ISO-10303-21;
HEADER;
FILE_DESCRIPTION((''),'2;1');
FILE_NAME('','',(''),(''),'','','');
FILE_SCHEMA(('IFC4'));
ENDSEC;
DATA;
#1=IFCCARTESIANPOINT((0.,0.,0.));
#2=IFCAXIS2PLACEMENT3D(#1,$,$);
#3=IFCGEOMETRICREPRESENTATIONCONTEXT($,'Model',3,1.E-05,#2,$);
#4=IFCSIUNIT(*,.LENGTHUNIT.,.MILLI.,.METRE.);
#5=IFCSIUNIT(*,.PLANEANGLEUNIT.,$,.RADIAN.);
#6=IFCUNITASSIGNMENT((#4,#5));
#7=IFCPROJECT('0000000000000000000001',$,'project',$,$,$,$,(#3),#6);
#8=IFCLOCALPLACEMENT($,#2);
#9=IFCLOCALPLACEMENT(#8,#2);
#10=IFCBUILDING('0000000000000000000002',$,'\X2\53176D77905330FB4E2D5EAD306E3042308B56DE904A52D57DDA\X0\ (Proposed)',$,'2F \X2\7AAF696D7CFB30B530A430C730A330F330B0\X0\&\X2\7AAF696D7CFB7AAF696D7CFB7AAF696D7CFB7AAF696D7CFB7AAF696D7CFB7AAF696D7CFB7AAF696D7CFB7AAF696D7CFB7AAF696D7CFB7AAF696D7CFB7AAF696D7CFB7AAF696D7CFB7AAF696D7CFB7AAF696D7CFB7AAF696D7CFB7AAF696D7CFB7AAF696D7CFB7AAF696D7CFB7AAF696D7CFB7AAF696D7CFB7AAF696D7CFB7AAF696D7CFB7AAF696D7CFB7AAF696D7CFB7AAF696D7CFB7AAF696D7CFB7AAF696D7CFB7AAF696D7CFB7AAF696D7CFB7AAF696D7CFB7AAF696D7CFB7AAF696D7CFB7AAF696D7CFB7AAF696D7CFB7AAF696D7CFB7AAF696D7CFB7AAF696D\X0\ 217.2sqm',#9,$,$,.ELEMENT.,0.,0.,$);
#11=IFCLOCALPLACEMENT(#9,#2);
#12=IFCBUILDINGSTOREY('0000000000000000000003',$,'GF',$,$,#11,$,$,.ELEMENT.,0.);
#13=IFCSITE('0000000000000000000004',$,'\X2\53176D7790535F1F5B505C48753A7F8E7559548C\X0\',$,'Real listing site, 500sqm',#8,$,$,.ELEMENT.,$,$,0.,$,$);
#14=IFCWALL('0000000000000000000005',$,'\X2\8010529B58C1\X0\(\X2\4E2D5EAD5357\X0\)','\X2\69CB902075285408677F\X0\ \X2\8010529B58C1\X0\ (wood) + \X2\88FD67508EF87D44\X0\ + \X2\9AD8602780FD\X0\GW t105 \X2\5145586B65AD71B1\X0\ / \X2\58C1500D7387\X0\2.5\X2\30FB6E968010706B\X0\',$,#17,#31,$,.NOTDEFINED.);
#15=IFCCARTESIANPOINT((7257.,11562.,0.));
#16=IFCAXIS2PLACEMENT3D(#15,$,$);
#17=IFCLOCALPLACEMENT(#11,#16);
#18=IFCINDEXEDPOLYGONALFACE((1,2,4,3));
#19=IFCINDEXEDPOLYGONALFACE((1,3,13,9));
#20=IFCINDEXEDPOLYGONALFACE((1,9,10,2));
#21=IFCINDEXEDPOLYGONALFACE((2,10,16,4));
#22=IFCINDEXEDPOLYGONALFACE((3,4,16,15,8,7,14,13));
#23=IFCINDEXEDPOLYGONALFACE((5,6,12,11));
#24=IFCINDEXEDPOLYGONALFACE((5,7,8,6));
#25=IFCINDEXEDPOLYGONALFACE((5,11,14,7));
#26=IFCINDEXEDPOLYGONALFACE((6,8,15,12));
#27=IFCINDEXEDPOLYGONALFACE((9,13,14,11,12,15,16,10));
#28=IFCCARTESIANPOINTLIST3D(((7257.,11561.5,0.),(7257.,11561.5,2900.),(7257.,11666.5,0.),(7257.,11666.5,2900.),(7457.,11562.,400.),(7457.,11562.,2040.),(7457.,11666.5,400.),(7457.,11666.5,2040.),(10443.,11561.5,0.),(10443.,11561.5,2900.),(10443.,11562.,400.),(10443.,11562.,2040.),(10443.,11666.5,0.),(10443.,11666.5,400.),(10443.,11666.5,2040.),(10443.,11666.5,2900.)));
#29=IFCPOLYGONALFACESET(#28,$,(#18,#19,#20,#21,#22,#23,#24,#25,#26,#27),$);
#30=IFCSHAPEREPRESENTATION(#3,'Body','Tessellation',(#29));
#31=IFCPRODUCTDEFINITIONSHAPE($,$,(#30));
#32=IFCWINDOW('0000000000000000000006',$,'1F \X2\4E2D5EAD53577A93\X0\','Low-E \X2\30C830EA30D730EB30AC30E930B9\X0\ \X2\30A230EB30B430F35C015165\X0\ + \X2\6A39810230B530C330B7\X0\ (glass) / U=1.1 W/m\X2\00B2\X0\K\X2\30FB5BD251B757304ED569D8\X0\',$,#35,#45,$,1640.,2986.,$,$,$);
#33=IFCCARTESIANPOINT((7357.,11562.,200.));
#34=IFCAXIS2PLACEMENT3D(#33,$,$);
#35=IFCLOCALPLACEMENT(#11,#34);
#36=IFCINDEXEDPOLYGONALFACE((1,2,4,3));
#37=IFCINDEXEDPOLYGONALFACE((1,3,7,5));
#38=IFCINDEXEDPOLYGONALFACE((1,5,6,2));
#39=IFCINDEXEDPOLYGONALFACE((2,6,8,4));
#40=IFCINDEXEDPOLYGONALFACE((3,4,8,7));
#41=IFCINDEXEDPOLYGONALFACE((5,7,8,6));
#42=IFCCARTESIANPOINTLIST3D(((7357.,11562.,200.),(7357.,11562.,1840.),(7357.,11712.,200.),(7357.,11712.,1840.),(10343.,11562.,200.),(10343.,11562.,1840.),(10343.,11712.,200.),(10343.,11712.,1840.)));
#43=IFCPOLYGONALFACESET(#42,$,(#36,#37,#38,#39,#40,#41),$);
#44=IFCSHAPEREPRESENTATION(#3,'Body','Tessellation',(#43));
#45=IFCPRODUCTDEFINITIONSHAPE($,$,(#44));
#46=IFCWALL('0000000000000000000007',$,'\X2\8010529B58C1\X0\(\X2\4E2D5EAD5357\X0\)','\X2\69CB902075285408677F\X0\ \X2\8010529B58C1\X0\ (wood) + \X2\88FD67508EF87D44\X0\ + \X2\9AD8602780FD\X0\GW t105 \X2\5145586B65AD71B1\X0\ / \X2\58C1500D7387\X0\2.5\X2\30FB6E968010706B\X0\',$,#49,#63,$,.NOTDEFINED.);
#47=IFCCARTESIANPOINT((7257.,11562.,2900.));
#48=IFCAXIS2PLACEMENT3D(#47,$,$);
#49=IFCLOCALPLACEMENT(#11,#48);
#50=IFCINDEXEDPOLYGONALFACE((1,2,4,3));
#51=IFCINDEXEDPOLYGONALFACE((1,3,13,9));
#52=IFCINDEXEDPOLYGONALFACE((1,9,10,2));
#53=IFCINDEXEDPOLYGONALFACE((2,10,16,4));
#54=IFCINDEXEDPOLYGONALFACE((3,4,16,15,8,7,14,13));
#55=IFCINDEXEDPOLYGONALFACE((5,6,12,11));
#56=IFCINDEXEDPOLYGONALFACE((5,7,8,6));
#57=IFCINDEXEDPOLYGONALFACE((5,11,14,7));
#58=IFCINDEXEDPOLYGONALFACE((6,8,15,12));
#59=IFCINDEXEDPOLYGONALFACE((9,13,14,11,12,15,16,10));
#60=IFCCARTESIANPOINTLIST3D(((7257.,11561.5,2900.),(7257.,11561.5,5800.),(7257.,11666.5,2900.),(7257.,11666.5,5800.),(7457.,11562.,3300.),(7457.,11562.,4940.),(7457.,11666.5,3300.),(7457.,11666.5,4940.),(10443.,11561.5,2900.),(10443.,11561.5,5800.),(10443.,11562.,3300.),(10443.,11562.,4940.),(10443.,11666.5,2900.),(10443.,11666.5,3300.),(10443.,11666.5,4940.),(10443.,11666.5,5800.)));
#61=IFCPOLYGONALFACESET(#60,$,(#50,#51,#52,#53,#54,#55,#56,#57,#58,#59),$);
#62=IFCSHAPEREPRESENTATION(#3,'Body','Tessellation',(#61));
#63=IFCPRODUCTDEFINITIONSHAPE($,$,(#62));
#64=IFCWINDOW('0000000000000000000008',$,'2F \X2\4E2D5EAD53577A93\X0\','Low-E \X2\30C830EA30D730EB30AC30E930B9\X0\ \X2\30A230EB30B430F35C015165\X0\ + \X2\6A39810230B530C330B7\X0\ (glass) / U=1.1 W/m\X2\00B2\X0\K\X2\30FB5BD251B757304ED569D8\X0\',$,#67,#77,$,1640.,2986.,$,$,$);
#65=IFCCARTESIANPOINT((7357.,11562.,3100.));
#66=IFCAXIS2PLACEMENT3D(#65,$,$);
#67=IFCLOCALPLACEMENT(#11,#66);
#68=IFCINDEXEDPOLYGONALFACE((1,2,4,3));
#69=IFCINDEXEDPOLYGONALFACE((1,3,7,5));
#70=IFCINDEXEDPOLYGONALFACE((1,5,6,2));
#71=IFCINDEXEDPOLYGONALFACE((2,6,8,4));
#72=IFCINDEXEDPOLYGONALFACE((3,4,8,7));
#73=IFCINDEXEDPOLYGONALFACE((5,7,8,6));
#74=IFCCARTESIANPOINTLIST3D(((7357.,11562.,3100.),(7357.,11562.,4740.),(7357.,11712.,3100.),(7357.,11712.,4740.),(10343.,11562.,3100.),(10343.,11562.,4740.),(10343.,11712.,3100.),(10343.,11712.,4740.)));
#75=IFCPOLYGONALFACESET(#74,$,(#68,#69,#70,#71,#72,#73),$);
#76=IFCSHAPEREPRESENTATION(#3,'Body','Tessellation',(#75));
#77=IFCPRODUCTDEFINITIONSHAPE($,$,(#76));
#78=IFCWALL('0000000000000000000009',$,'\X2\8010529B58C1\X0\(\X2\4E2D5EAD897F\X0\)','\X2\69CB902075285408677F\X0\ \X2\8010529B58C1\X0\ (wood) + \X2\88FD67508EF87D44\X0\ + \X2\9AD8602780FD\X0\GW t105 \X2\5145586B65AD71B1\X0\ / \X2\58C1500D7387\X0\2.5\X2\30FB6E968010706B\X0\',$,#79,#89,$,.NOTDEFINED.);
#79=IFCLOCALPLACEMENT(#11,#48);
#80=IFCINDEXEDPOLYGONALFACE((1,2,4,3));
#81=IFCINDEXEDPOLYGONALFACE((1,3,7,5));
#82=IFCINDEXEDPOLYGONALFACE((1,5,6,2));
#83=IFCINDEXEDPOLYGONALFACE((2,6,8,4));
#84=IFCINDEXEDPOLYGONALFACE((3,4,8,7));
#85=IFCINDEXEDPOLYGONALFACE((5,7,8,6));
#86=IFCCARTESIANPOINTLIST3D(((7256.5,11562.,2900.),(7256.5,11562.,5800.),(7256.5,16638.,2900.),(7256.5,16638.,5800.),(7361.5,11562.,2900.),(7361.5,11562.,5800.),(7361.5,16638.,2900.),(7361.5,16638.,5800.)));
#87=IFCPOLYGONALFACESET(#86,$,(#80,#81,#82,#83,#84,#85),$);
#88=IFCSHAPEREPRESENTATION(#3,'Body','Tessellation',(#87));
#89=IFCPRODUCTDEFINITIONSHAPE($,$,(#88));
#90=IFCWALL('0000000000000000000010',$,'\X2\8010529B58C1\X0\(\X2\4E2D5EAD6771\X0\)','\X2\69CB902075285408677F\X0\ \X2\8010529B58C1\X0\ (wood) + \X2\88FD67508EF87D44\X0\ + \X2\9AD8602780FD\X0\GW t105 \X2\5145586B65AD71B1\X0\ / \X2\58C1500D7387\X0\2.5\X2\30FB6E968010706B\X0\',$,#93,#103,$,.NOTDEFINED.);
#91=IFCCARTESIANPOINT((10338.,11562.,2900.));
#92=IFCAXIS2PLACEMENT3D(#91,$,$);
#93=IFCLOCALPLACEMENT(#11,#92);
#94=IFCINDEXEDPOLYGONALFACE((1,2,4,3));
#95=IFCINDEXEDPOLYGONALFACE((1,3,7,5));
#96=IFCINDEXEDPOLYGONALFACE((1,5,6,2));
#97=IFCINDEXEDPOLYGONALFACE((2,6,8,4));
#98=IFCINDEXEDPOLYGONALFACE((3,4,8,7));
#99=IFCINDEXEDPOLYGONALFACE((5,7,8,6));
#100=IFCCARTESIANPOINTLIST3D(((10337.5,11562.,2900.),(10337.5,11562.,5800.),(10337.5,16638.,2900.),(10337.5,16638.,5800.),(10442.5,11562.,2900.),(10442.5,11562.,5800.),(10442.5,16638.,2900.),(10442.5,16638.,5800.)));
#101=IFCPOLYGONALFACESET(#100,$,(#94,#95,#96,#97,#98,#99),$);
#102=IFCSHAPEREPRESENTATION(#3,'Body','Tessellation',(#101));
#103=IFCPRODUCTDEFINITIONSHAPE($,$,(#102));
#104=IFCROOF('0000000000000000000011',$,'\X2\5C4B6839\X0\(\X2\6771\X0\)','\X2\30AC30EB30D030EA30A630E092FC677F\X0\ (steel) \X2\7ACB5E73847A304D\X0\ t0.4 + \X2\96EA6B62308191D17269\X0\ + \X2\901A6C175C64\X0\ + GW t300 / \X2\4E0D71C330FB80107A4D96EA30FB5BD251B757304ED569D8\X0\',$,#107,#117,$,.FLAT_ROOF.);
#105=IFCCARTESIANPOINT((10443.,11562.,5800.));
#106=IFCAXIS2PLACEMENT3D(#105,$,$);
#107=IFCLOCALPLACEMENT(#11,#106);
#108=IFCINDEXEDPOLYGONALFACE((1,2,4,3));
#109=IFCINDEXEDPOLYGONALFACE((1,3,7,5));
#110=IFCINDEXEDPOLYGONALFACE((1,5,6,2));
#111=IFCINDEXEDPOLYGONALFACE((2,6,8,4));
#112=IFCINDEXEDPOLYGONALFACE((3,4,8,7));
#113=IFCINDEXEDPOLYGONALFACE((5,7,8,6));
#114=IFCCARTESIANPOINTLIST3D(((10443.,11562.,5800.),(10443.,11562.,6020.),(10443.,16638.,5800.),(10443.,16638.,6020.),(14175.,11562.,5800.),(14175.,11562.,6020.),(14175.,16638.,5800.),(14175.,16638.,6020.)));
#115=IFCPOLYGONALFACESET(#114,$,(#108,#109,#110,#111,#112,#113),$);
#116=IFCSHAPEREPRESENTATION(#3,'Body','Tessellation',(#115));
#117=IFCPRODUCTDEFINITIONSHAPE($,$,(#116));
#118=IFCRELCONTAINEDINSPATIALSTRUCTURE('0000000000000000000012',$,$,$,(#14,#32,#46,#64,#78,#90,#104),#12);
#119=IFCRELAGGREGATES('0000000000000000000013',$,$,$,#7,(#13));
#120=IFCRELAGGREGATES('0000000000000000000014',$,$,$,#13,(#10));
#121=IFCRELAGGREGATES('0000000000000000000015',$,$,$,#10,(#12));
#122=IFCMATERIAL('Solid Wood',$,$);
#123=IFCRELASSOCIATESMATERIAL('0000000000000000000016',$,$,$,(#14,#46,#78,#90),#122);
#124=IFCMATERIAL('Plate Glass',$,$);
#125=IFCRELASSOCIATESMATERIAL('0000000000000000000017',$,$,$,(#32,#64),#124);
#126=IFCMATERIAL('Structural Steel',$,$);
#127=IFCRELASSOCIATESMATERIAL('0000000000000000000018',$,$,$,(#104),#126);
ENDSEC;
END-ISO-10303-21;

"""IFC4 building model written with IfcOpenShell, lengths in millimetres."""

from ifc_helpers import new_model, si_unit, frame, frame_2d, origin, place, context, project, spatial, rectangle, extrude, material, element, fill, save


model = new_model("IFC4")

# Units and contexts
model_context = context("Model", 3, precision=1e-05, world=origin())
ifc_project = project(units=[si_unit("LENGTHUNIT", "METRE", prefix="MILLI"), si_unit("PLANEANGLEUNIT", "RADIAN")], contexts=[model_context])

# Site, building, storey
site_placement = place(None, origin())
site = spatial("IfcSite", under=ifc_project, at=site_placement, Name="北海道弟子屈町美留和", ObjectType="Real listing site, 500sqm", CompositionType="ELEMENT", RefElevation=0.0)
building_placement = place(site_placement, origin())
building = spatial("IfcBuilding", under=site, at=building_placement, Name="北海道・中庭のある回遊動線 (Proposed)", ObjectType="2F 窯業系サイディング&窯業系窯業系窯業系窯業系窯業系窯業系窯業系窯業系窯業系窯業系窯業系窯業系窯業系窯業系窯業系窯業系窯業系窯業系窯業系窯業系窯業系窯業系窯業系窯業系窯業系窯業系窯業系窯業系窯業系窯業系窯業系窯業系窯業系窯業系窯業系窯業系窯業 217.2sqm", CompositionType="ELEMENT", ElevationOfRefHeight=0.0, ElevationOfTerrain=0.0)
storey_placement = place(building_placement, origin())
storey = spatial("IfcBuildingStorey", under=building, at=storey_placement, Name="GF", CompositionType="ELEMENT", Elevation=0.0)

# Shared definitions
ifc_material_1 = material(Name="Solid Wood")

# Wall, opening, window
wall_1_placement = place(storey_placement, frame((7257.0, 11562.0, 0.0)))
wall_1 = element("IfcWall", 1, at=wall_1_placement, inside=storey, material=ifc_material_1, Name="耐力壁(中庭南)", Description="構造用合板 耐力壁 (wood) + 製材軸組 + 高性能GW t105 充填断熱 / 壁倍率2.5・準耐火", PredefinedType="NOTDEFINED", context=model_context, shape_type="SweptSolid", body=[
    extrude(rectangle(XDim=3186.0, YDim=105.0, at=frame_2d((1593.0, 52.0))), frame((7257.0, 11562.0, 0.0)), (0.0, 0.0, 1.0), 2900.0),
])
opening_1_placement = place(storey_placement, frame((7357.0, 11562.0, 200.0)))
opening_1 = element("IfcOpeningElement", 2, at=opening_1_placement, cuts=wall_1, PredefinedType="NOTDEFINED", context=model_context, shape_type="SweptSolid", body=[
    extrude(rectangle(XDim=2986.0, YDim=150.0, at=frame_2d((1493.0, 75.0))), frame((7357.0, 11562.0, 200.0)), (0.0, 0.0, 1.0), 1640.0),
])
ifc_material_2 = material(Name="Plate Glass")
window_1_placement = place(storey_placement, frame((7357.0, 11562.0, 200.0)))
window_1 = element("IfcWindow", 3, at=window_1_placement, inside=storey, material=ifc_material_2, Name="1F 中庭南窓", Description="Low-E トリプルガラス アルゴン封入 + 樹脂サッシ (glass) / U=1.1 W/m²K・寒冷地仕様", OverallHeight=1640.0, OverallWidth=2986.0, context=model_context, shape_type="SweptSolid", body=[
    extrude(rectangle(XDim=2986.0, YDim=150.0, at=frame_2d((1493.0, 75.0))), frame((7357.0, 11562.0, 200.0)), (0.0, 0.0, 1.0), 1640.0),
])
fill(opening_1, window_1)

# Wall, opening, window
wall_2_placement = place(storey_placement, frame((7257.0, 11562.0, 2900.0)))
wall_2 = element("IfcWall", 4, at=wall_2_placement, inside=storey, material=ifc_material_1, Name="耐力壁(中庭南)", Description="構造用合板 耐力壁 (wood) + 製材軸組 + 高性能GW t105 充填断熱 / 壁倍率2.5・準耐火", PredefinedType="NOTDEFINED", context=model_context, shape_type="SweptSolid", body=[
    extrude(rectangle(XDim=3186.0, YDim=105.0, at=frame_2d((1593.0, 52.0))), frame((7257.0, 11562.0, 2900.0)), (0.0, 0.0, 1.0), 2900.0),
])
opening_2_placement = place(storey_placement, frame((7357.0, 11562.0, 3100.0)))
opening_2 = element("IfcOpeningElement", 5, at=opening_2_placement, cuts=wall_2, PredefinedType="NOTDEFINED", context=model_context, shape_type="SweptSolid", body=[
    extrude(rectangle(XDim=2986.0, YDim=150.0, at=frame_2d((1493.0, 75.0))), frame((7357.0, 11562.0, 3100.0)), (0.0, 0.0, 1.0), 1640.0),
])
window_2_placement = place(storey_placement, frame((7357.0, 11562.0, 3100.0)))
window_2 = element("IfcWindow", 6, at=window_2_placement, inside=storey, material=ifc_material_2, Name="2F 中庭南窓", Description="Low-E トリプルガラス アルゴン封入 + 樹脂サッシ (glass) / U=1.1 W/m²K・寒冷地仕様", OverallHeight=1640.0, OverallWidth=2986.0, context=model_context, shape_type="SweptSolid", body=[
    extrude(rectangle(XDim=2986.0, YDim=150.0, at=frame_2d((1493.0, 75.0))), frame((7357.0, 11562.0, 3100.0)), (0.0, 0.0, 1.0), 1640.0),
])
fill(opening_2, window_2)

# Walls
wall_3_placement = place(storey_placement, frame((7257.0, 11562.0, 2900.0)))
element("IfcWall", 7, at=wall_3_placement, inside=storey, material=ifc_material_1, Name="耐力壁(中庭西)", Description="構造用合板 耐力壁 (wood) + 製材軸組 + 高性能GW t105 充填断熱 / 壁倍率2.5・準耐火", PredefinedType="NOTDEFINED", context=model_context, shape_type="SweptSolid", body=[
    extrude(rectangle(XDim=105.0, YDim=5076.0, at=frame_2d((52.0, 2538.0))), frame((7257.0, 11562.0, 2900.0)), (0.0, 0.0, 1.0), 2900.0),
])
wall_4_placement = place(storey_placement, frame((10338.0, 11562.0, 2900.0)))
element("IfcWall", 8, at=wall_4_placement, inside=storey, material=ifc_material_1, Name="耐力壁(中庭東)", Description="構造用合板 耐力壁 (wood) + 製材軸組 + 高性能GW t105 充填断熱 / 壁倍率2.5・準耐火", PredefinedType="NOTDEFINED", context=model_context, shape_type="SweptSolid", body=[
    extrude(rectangle(XDim=105.0, YDim=5076.0, at=frame_2d((52.0, 2538.0))), frame((10338.0, 11562.0, 2900.0)), (0.0, 0.0, 1.0), 2900.0),
])

# Roof
ifc_material_3 = material(Name="Structural Steel")
for number, where, name in (
    (9, (10443.0, 11562.0, 5800.0), "屋根(東)"),
):
    element("IfcRoof", number, at=place(storey_placement, frame(where)), inside=storey, material=ifc_material_3, Name=name, Description="ガルバリウム鋼板 (steel) 立平葺き t0.4 + 雪止め金物 + 通気層 + GW t300 / 不燃・耐積雪・寒冷地仕様", PredefinedType="FLAT_ROOF", context=model_context, shape_type="SweptSolid", body=[
        extrude(rectangle(XDim=3732.0, YDim=5076.0, at=frame_2d((1866.0, 2538.0))), frame((10443.0, 11562.0, 5800.0)), (0.0, 0.0, 1.0), 220.0),
    ])

save(model, "model.ifc")
